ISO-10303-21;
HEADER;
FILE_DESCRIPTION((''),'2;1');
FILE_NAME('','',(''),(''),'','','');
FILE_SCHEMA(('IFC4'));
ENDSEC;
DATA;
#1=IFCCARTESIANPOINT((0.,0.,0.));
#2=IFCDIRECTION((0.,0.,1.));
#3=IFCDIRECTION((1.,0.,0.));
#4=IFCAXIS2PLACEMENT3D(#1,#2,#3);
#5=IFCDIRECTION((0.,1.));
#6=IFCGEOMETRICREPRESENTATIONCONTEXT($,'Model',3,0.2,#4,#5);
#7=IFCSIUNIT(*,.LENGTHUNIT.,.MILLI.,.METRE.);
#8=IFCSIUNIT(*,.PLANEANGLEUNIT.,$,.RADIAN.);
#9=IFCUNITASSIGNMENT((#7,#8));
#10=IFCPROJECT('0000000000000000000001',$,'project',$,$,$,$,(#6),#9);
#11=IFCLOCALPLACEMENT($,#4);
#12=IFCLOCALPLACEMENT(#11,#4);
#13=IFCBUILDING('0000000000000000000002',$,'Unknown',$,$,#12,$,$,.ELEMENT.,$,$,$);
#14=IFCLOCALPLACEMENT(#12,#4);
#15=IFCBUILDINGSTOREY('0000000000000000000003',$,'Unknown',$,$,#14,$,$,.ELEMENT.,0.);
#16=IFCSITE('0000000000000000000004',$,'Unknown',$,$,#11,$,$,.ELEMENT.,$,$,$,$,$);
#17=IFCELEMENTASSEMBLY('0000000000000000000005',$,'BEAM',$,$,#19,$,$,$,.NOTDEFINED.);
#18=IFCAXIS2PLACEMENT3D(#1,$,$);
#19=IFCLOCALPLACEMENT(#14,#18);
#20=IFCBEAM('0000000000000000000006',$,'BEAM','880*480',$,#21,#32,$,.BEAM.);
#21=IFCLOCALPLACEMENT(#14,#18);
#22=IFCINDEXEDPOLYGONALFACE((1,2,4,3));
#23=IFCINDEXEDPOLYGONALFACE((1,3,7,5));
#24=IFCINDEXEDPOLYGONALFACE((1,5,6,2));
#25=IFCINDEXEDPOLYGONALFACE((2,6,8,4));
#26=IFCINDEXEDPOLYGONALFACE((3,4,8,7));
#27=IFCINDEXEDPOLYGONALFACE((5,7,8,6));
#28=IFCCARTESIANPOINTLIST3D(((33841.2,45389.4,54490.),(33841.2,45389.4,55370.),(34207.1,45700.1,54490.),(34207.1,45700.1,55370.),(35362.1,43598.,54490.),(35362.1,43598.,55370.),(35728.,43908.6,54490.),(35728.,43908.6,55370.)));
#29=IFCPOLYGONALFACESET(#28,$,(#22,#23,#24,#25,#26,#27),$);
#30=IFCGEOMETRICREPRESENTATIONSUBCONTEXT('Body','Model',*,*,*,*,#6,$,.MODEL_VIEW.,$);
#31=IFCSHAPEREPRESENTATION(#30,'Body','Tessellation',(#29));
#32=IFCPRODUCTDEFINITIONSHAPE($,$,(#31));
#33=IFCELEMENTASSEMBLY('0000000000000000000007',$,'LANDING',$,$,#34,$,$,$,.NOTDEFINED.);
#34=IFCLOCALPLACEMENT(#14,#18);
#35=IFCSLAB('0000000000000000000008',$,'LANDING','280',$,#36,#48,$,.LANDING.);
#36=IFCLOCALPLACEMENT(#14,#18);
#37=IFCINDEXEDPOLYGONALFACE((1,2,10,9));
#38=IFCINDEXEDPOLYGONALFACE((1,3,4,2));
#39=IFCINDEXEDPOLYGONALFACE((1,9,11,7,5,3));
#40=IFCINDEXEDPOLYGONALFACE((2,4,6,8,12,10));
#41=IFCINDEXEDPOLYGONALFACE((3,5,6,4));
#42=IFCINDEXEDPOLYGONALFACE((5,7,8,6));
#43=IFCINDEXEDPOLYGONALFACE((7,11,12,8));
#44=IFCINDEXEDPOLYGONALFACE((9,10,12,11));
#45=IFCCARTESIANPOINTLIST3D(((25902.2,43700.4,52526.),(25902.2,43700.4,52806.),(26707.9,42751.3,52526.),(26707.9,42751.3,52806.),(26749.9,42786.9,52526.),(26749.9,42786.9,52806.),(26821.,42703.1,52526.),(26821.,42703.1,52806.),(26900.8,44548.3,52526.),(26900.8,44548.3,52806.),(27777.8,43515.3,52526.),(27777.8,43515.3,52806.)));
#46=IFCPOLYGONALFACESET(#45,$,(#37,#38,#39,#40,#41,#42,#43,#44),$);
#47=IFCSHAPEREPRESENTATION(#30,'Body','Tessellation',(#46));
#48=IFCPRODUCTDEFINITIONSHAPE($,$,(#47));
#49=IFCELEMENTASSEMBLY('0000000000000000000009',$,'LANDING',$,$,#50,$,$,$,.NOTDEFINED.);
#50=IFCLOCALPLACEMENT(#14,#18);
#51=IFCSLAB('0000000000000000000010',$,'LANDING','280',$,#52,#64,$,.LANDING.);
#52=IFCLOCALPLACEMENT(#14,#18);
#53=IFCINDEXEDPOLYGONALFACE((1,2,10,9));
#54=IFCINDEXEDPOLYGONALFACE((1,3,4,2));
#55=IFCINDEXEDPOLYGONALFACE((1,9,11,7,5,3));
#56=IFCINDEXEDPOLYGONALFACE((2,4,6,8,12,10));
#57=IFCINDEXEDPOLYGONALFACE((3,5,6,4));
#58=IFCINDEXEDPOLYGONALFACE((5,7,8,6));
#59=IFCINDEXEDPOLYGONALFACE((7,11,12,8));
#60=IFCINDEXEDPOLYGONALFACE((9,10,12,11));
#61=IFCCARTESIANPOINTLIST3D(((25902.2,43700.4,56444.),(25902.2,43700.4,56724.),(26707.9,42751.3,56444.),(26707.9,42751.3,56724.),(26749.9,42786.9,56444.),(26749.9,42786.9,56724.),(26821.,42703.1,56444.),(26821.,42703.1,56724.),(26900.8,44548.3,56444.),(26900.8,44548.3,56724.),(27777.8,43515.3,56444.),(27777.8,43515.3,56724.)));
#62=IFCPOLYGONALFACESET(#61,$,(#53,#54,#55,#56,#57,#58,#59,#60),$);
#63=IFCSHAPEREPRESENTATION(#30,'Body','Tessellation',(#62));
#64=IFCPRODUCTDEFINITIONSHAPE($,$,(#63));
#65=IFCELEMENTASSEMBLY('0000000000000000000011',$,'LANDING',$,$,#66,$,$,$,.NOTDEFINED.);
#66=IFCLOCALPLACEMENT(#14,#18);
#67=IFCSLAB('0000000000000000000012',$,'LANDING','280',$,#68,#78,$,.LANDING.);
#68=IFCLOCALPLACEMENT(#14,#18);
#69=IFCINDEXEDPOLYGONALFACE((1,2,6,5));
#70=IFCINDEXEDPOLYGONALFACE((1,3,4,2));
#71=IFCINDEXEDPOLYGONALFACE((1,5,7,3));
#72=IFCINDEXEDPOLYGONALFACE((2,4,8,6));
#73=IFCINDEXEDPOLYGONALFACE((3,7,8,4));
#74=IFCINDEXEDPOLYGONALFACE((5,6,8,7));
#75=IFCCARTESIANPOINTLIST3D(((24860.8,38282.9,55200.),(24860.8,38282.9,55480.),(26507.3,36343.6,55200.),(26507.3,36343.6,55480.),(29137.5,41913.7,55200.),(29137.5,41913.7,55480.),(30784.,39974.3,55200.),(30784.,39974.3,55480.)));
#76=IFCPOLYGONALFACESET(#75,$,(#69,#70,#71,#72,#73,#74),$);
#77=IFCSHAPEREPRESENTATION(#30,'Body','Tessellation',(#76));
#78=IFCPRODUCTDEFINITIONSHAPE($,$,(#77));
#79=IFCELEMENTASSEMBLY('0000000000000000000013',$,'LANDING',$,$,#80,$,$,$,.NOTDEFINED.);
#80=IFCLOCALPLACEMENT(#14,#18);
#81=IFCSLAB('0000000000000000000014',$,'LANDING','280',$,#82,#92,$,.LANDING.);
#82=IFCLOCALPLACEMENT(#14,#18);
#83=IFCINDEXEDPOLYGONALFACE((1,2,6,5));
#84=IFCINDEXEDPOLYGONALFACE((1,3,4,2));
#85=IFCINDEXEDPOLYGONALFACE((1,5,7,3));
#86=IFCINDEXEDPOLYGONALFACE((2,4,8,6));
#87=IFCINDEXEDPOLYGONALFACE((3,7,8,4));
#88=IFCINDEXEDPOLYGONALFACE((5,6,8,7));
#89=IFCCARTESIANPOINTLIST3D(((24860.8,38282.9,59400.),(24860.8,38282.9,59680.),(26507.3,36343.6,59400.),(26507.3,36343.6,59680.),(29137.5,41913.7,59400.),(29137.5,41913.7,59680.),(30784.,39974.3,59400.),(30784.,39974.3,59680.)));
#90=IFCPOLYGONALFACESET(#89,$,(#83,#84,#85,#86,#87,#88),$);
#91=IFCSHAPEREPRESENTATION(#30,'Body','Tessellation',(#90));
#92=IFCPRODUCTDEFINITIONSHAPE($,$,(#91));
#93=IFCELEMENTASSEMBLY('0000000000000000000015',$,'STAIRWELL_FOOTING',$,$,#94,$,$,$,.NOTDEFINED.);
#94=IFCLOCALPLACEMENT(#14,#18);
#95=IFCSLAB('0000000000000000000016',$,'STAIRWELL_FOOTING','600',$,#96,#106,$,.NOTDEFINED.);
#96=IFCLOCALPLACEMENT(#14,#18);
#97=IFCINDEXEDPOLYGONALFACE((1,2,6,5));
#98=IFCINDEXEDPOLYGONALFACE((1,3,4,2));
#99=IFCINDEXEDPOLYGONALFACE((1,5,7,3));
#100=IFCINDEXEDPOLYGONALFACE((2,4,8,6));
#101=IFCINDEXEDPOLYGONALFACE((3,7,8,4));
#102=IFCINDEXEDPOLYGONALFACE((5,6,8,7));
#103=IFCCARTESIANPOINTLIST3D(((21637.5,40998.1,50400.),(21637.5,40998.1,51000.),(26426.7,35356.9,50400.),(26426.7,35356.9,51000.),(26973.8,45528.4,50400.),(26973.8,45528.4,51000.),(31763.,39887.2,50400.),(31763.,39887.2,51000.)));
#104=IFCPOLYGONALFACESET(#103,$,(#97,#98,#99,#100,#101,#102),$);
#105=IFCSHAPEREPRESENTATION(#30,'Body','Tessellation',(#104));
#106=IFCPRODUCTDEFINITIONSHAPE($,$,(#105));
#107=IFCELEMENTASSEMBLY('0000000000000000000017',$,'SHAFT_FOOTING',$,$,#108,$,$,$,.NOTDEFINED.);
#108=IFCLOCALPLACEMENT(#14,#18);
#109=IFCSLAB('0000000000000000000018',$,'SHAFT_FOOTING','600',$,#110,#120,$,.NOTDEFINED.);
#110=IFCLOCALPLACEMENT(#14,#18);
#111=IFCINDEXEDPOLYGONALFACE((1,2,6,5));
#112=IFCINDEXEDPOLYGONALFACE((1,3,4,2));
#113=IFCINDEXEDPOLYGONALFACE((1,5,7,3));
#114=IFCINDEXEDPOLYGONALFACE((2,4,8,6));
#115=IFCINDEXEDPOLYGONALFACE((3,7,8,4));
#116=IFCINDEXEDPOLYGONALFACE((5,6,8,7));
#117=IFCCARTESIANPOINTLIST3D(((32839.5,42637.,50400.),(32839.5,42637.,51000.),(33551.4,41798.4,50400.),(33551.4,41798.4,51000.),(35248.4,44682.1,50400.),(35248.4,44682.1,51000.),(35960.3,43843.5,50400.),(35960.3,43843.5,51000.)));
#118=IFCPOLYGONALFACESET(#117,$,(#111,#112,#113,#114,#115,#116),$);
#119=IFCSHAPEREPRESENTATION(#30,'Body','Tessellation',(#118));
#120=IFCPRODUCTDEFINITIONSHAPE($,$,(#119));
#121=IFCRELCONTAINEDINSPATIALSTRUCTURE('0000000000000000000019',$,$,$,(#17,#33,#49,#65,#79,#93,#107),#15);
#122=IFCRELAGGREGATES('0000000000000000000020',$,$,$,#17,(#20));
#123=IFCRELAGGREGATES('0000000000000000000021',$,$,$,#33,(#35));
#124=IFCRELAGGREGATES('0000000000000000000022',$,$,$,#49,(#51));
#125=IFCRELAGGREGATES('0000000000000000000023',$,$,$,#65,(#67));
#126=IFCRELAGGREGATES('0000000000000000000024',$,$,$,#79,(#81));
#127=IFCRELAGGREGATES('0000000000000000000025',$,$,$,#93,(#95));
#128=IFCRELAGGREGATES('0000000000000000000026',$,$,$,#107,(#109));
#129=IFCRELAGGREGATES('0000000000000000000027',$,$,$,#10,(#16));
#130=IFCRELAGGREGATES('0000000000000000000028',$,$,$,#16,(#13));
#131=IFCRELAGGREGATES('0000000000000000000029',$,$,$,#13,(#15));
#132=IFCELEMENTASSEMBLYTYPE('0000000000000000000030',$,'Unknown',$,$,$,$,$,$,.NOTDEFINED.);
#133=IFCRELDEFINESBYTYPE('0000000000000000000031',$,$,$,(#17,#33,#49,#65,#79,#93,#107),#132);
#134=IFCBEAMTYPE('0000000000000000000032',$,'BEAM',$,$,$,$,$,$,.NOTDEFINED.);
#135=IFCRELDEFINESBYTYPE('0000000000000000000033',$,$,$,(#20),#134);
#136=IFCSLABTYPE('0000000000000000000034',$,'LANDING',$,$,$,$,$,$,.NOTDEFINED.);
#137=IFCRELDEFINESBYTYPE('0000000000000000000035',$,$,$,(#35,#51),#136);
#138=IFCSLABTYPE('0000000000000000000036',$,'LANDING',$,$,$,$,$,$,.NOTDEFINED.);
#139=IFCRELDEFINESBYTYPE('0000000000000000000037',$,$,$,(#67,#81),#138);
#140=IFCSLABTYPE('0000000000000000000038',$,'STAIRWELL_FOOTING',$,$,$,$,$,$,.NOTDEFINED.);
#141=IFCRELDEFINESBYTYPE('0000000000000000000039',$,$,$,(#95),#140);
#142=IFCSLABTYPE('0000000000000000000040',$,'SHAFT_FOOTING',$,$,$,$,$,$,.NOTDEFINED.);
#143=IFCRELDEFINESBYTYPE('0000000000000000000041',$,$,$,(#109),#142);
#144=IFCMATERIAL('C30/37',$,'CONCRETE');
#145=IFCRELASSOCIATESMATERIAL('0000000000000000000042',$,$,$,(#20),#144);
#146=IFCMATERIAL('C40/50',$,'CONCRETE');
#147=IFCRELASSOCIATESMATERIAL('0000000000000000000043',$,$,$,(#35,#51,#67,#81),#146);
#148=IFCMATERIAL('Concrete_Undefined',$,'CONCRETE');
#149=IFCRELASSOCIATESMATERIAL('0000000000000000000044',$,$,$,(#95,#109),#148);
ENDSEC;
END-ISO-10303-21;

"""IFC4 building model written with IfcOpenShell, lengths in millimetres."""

from ifc_helpers import new_model, si_unit, direction, frame, origin_with_axes, origin_2d_with_axis, place, context, subcontext, project, spatial, line, indexed_curve, rectangle, outline, extrude, material, material_profile, profile_set, profile_usage, type_object, element, aggregate, save


model = new_model("IFC4")

# Units and contexts
model_context = context("Model", 3, precision=0.2, world=origin_with_axes(), true_north=direction((0.0, 1.0)))
body_context = subcontext(model_context, "Body", "Model", "MODEL_VIEW")
ifc_project = project(units=[si_unit("LENGTHUNIT", "METRE", prefix="MILLI"), si_unit("PLANEANGLEUNIT", "RADIAN")], contexts=[model_context])

# Site, building, storey
site_placement = place(None, origin_with_axes())
site = spatial("IfcSite", under=ifc_project, at=site_placement, Name="Unknown", CompositionType="ELEMENT")
building_placement = place(site_placement, origin_with_axes())
building = spatial("IfcBuilding", under=site, at=building_placement, Name="Unknown", CompositionType="ELEMENT")
storey_placement = place(building_placement, origin_with_axes())
storey = spatial("IfcBuildingStorey", under=building, at=storey_placement, Name="Unknown", CompositionType="ELEMENT", Elevation=0.0)

# Shared definitions
element_assembly_type = type_object("IfcElementAssemblyType", Name="Unknown", PredefinedType="NOTDEFINED")
ifc_material_1 = material(Name="C40/50", Category="CONCRETE")

# Element assembly, beam
ifc_material_2 = material(Name="C30/37", Category="CONCRETE")
assembly_1_placement = place(storey_placement, frame((35545.0, 43753.3, 54930.0), z_axis=(0.762329, 0.64719, 0.0), x_axis=(-0.64719, 0.762329, 0.0)))
assembly_1 = element("IfcElementAssembly", 1, at=assembly_1_placement, inside=storey, type_object=element_assembly_type, Name="BEAM", PredefinedType="NOTDEFINED")
ifc_material_profile_1 = material_profile(ifc_material_2, rectangle(XDim=480.0, YDim=880.0, at=origin_2d_with_axis()), Name="880*480")
ifc_profile_set_1 = profile_set([ifc_material_profile_1])
ifc_profile_usage_1 = profile_usage(ifc_profile_set_1, cardinal=8)
beam_type_1 = type_object("IfcBeamType", Name="BEAM")
beam_1_placement = place(assembly_1_placement, origin_with_axes())
beam_1 = element("IfcBeam", 2, at=beam_1_placement, type_object=beam_type_1, material=ifc_profile_usage_1, Name="BEAM", Description="880*480", PredefinedType="BEAM", context=body_context, shape_type="SolidModel", body=[
    extrude(rectangle(XDim=480.0, YDim=880.0, at=origin_2d_with_axis()), frame((0.0, 0.0, 0.0), z_axis=(-1.0, 0.0, 0.0), x_axis=(0.0, 0.0, 1.0)), (0.0, 0.0, -1.0), 2350.0),
])
aggregate(assembly_1, [beam_1])

# Element assemblies, slabs
assembly_2_placement = place(storey_placement, frame((27777.8, 43515.3, 52666.0), z_axis=(0.0, 0.0, 1.0), x_axis=(-0.64719, 0.762329, 0.0)))
assembly_2 = element("IfcElementAssembly", 3, at=assembly_2_placement, inside=storey, type_object=element_assembly_type, Name="LANDING", PredefinedType="NOTDEFINED")
ifc_material_profile_2 = material_profile(ifc_material_1, outline(indexed_curve([(0.0, 0.0), (1355.0, 0.0), (1355.0, 1310.0), (110.0, 1310.0), (110.0, 1255.0), (0.0, 1255.0)], segments=[line(1, 2, 3, 4, 5, 6, 1)])), Name="280")
ifc_profile_set_2 = profile_set([ifc_material_profile_2])
ifc_profile_usage_2 = profile_usage(ifc_profile_set_2, cardinal=8)
slab_type_1 = type_object("IfcSlabType", Name="LANDING")
slab_1_placement = place(assembly_2_placement, origin_with_axes())
slab_1 = element("IfcSlab", 4, at=slab_1_placement, type_object=slab_type_1, material=ifc_profile_usage_2, Name="LANDING", Description="280", PredefinedType="LANDING", context=body_context, shape_type="SolidModel", body=[
    extrude(outline(indexed_curve([(0.0, 0.0), (1355.0, 0.0), (1355.0, 1310.0), (110.0, 1310.0), (110.0, 1255.0), (0.0, 1255.0)], segments=[line(1, 2, 3, 4, 5, 6, 1)])), frame((0.0, 0.0, 140.0), z_axis=(0.0, 0.0, 1.0), x_axis=(1.0, 0.0, 0.0)), (0.0, 0.0, -1.0), 280.0),
])
aggregate(assembly_2, [slab_1])
assembly_3_placement = place(storey_placement, frame((27777.8, 43515.3, 56584.0), z_axis=(0.0, 0.0, 1.0), x_axis=(-0.64719, 0.762329, 0.0)))
assembly_3 = element("IfcElementAssembly", 5, at=assembly_3_placement, inside=storey, type_object=element_assembly_type, Name="LANDING", PredefinedType="NOTDEFINED")
slab_2_placement = place(assembly_3_placement, origin_with_axes())
slab_2 = element("IfcSlab", 6, at=slab_2_placement, type_object=slab_type_1, material=ifc_profile_usage_2, Name="LANDING", Description="280", PredefinedType="LANDING", context=body_context, shape_type="SolidModel", body=[
    extrude(outline(indexed_curve([(0.0, 0.0), (1355.0, 0.0), (1355.0, 1310.0), (110.0, 1310.0), (110.0, 1255.0), (0.0, 1255.0)], segments=[line(1, 2, 3, 4, 5, 6, 1)])), frame((0.0, 0.0, 140.0), z_axis=(0.0, 0.0, 1.0), x_axis=(1.0, 0.0, 0.0)), (0.0, 0.0, -1.0), 280.0),
])
aggregate(assembly_3, [slab_2])
assembly_4_placement = place(storey_placement, frame((26507.3, 36343.6, 55340.0), z_axis=(0.0, 0.0, 1.0), x_axis=(0.762329, 0.64719, 0.0)))
assembly_4 = element("IfcElementAssembly", 7, at=assembly_4_placement, inside=storey, type_object=element_assembly_type, Name="LANDING", PredefinedType="NOTDEFINED")
ifc_material_profile_3 = material_profile(ifc_material_1, outline(indexed_curve([(0.0, 0.0), (5610.0, 0.0), (5610.0, 2544.0), (0.0, 2544.0)], segments=[line(1, 2, 3, 4, 1)])), Name="280")
ifc_profile_set_3 = profile_set([ifc_material_profile_3])
ifc_profile_usage_3 = profile_usage(ifc_profile_set_3, cardinal=8)
slab_type_2 = type_object("IfcSlabType", Name="LANDING")
slab_3_placement = place(assembly_4_placement, origin_with_axes())
slab_3 = element("IfcSlab", 8, at=slab_3_placement, type_object=slab_type_2, material=ifc_profile_usage_3, Name="LANDING", Description="280", PredefinedType="LANDING", context=body_context, shape_type="SolidModel", body=[
    extrude(outline(indexed_curve([(0.0, 0.0), (5610.0, 0.0), (5610.0, 2544.0), (0.0, 2544.0)], segments=[line(1, 2, 3, 4, 1)])), frame((0.0, 0.0, 140.0), z_axis=(0.0, 0.0, 1.0), x_axis=(1.0, 0.0, 0.0)), (0.0, 0.0, -1.0), 280.0),
])
aggregate(assembly_4, [slab_3])
assembly_5_placement = place(storey_placement, frame((26507.3, 36343.6, 59540.0), z_axis=(0.0, 0.0, 1.0), x_axis=(0.762329, 0.64719, 0.0)))
assembly_5 = element("IfcElementAssembly", 9, at=assembly_5_placement, inside=storey, type_object=element_assembly_type, Name="LANDING", PredefinedType="NOTDEFINED")
slab_4_placement = place(assembly_5_placement, origin_with_axes())
slab_4 = element("IfcSlab", 10, at=slab_4_placement, type_object=slab_type_2, material=ifc_profile_usage_3, Name="LANDING", Description="280", PredefinedType="LANDING", context=body_context, shape_type="SolidModel", body=[
    extrude(outline(indexed_curve([(0.0, 0.0), (5610.0, 0.0), (5610.0, 2544.0), (0.0, 2544.0)], segments=[line(1, 2, 3, 4, 1)])), frame((0.0, 0.0, 140.0), z_axis=(0.0, 0.0, 1.0), x_axis=(1.0, 0.0, 0.0)), (0.0, 0.0, -1.0), 280.0),
])
aggregate(assembly_5, [slab_4])
assembly_6_placement = place(storey_placement, frame((26973.8, 45528.4, 50700.0), z_axis=(0.0, 0.0, 1.0), x_axis=(-0.762329, -0.64719, 0.0)))
assembly_6 = element("IfcElementAssembly", 11, at=assembly_6_placement, inside=storey, type_object=element_assembly_type, Name="STAIRWELL_FOOTING", PredefinedType="NOTDEFINED")
ifc_material_3 = material(Name="Concrete_Undefined", Category="CONCRETE")
ifc_material_profile_4 = material_profile(ifc_material_3, outline(indexed_curve([(0.0, 0.0), (7000.0, 0.0), (7000.0, 7400.0), (0.0, 7400.0)], segments=[line(1, 2, 3, 4, 1)])), Name="600")
ifc_profile_set_4 = profile_set([ifc_material_profile_4])
ifc_profile_usage_4 = profile_usage(ifc_profile_set_4, cardinal=8)
slab_type_3 = type_object("IfcSlabType", Name="STAIRWELL_FOOTING")
slab_5_placement = place(assembly_6_placement, origin_with_axes())
slab_5 = element("IfcSlab", 12, at=slab_5_placement, type_object=slab_type_3, material=ifc_profile_usage_4, Name="STAIRWELL_FOOTING", Description="600", PredefinedType="NOTDEFINED", context=body_context, shape_type="SolidModel", body=[
    extrude(outline(indexed_curve([(0.0, 0.0), (7000.0, 0.0), (7000.0, 7400.0), (0.0, 7400.0)], segments=[line(1, 2, 3, 4, 1)])), frame((0.0, 0.0, 300.0), z_axis=(0.0, 0.0, 1.0), x_axis=(1.0, 0.0, 0.0)), (0.0, 0.0, -1.0), 600.0),
])
aggregate(assembly_6, [slab_5])
assembly_7_placement = place(storey_placement, frame((35248.4, 44682.1, 50700.0), z_axis=(0.0, 0.0, 1.0), x_axis=(-0.762329, -0.64719, 0.0)))
assembly_7 = element("IfcElementAssembly", 13, at=assembly_7_placement, inside=storey, type_object=element_assembly_type, Name="SHAFT_FOOTING", PredefinedType="NOTDEFINED")
ifc_material_profile_5 = material_profile(ifc_material_3, outline(indexed_curve([(0.0, 0.0), (3160.0, 0.0), (3160.0, 1100.0), (0.0, 1100.0)], segments=[line(1, 2, 3, 4, 1)])), Name="600")
ifc_profile_set_5 = profile_set([ifc_material_profile_5])
ifc_profile_usage_5 = profile_usage(ifc_profile_set_5, cardinal=8)
slab_type_4 = type_object("IfcSlabType", Name="SHAFT_FOOTING")
slab_6_placement = place(assembly_7_placement, origin_with_axes())
slab_6 = element("IfcSlab", 14, at=slab_6_placement, type_object=slab_type_4, material=ifc_profile_usage_5, Name="SHAFT_FOOTING", Description="600", PredefinedType="NOTDEFINED", context=body_context, shape_type="SolidModel", body=[
    extrude(outline(indexed_curve([(0.0, 0.0), (3160.0, 0.0), (3160.0, 1100.0), (0.0, 1100.0)], segments=[line(1, 2, 3, 4, 1)])), frame((0.0, 0.0, 300.0), z_axis=(0.0, 0.0, 1.0), x_axis=(1.0, 0.0, 0.0)), (0.0, 0.0, -1.0), 600.0),
])
aggregate(assembly_7, [slab_6])

save(model, "model.ifc")
